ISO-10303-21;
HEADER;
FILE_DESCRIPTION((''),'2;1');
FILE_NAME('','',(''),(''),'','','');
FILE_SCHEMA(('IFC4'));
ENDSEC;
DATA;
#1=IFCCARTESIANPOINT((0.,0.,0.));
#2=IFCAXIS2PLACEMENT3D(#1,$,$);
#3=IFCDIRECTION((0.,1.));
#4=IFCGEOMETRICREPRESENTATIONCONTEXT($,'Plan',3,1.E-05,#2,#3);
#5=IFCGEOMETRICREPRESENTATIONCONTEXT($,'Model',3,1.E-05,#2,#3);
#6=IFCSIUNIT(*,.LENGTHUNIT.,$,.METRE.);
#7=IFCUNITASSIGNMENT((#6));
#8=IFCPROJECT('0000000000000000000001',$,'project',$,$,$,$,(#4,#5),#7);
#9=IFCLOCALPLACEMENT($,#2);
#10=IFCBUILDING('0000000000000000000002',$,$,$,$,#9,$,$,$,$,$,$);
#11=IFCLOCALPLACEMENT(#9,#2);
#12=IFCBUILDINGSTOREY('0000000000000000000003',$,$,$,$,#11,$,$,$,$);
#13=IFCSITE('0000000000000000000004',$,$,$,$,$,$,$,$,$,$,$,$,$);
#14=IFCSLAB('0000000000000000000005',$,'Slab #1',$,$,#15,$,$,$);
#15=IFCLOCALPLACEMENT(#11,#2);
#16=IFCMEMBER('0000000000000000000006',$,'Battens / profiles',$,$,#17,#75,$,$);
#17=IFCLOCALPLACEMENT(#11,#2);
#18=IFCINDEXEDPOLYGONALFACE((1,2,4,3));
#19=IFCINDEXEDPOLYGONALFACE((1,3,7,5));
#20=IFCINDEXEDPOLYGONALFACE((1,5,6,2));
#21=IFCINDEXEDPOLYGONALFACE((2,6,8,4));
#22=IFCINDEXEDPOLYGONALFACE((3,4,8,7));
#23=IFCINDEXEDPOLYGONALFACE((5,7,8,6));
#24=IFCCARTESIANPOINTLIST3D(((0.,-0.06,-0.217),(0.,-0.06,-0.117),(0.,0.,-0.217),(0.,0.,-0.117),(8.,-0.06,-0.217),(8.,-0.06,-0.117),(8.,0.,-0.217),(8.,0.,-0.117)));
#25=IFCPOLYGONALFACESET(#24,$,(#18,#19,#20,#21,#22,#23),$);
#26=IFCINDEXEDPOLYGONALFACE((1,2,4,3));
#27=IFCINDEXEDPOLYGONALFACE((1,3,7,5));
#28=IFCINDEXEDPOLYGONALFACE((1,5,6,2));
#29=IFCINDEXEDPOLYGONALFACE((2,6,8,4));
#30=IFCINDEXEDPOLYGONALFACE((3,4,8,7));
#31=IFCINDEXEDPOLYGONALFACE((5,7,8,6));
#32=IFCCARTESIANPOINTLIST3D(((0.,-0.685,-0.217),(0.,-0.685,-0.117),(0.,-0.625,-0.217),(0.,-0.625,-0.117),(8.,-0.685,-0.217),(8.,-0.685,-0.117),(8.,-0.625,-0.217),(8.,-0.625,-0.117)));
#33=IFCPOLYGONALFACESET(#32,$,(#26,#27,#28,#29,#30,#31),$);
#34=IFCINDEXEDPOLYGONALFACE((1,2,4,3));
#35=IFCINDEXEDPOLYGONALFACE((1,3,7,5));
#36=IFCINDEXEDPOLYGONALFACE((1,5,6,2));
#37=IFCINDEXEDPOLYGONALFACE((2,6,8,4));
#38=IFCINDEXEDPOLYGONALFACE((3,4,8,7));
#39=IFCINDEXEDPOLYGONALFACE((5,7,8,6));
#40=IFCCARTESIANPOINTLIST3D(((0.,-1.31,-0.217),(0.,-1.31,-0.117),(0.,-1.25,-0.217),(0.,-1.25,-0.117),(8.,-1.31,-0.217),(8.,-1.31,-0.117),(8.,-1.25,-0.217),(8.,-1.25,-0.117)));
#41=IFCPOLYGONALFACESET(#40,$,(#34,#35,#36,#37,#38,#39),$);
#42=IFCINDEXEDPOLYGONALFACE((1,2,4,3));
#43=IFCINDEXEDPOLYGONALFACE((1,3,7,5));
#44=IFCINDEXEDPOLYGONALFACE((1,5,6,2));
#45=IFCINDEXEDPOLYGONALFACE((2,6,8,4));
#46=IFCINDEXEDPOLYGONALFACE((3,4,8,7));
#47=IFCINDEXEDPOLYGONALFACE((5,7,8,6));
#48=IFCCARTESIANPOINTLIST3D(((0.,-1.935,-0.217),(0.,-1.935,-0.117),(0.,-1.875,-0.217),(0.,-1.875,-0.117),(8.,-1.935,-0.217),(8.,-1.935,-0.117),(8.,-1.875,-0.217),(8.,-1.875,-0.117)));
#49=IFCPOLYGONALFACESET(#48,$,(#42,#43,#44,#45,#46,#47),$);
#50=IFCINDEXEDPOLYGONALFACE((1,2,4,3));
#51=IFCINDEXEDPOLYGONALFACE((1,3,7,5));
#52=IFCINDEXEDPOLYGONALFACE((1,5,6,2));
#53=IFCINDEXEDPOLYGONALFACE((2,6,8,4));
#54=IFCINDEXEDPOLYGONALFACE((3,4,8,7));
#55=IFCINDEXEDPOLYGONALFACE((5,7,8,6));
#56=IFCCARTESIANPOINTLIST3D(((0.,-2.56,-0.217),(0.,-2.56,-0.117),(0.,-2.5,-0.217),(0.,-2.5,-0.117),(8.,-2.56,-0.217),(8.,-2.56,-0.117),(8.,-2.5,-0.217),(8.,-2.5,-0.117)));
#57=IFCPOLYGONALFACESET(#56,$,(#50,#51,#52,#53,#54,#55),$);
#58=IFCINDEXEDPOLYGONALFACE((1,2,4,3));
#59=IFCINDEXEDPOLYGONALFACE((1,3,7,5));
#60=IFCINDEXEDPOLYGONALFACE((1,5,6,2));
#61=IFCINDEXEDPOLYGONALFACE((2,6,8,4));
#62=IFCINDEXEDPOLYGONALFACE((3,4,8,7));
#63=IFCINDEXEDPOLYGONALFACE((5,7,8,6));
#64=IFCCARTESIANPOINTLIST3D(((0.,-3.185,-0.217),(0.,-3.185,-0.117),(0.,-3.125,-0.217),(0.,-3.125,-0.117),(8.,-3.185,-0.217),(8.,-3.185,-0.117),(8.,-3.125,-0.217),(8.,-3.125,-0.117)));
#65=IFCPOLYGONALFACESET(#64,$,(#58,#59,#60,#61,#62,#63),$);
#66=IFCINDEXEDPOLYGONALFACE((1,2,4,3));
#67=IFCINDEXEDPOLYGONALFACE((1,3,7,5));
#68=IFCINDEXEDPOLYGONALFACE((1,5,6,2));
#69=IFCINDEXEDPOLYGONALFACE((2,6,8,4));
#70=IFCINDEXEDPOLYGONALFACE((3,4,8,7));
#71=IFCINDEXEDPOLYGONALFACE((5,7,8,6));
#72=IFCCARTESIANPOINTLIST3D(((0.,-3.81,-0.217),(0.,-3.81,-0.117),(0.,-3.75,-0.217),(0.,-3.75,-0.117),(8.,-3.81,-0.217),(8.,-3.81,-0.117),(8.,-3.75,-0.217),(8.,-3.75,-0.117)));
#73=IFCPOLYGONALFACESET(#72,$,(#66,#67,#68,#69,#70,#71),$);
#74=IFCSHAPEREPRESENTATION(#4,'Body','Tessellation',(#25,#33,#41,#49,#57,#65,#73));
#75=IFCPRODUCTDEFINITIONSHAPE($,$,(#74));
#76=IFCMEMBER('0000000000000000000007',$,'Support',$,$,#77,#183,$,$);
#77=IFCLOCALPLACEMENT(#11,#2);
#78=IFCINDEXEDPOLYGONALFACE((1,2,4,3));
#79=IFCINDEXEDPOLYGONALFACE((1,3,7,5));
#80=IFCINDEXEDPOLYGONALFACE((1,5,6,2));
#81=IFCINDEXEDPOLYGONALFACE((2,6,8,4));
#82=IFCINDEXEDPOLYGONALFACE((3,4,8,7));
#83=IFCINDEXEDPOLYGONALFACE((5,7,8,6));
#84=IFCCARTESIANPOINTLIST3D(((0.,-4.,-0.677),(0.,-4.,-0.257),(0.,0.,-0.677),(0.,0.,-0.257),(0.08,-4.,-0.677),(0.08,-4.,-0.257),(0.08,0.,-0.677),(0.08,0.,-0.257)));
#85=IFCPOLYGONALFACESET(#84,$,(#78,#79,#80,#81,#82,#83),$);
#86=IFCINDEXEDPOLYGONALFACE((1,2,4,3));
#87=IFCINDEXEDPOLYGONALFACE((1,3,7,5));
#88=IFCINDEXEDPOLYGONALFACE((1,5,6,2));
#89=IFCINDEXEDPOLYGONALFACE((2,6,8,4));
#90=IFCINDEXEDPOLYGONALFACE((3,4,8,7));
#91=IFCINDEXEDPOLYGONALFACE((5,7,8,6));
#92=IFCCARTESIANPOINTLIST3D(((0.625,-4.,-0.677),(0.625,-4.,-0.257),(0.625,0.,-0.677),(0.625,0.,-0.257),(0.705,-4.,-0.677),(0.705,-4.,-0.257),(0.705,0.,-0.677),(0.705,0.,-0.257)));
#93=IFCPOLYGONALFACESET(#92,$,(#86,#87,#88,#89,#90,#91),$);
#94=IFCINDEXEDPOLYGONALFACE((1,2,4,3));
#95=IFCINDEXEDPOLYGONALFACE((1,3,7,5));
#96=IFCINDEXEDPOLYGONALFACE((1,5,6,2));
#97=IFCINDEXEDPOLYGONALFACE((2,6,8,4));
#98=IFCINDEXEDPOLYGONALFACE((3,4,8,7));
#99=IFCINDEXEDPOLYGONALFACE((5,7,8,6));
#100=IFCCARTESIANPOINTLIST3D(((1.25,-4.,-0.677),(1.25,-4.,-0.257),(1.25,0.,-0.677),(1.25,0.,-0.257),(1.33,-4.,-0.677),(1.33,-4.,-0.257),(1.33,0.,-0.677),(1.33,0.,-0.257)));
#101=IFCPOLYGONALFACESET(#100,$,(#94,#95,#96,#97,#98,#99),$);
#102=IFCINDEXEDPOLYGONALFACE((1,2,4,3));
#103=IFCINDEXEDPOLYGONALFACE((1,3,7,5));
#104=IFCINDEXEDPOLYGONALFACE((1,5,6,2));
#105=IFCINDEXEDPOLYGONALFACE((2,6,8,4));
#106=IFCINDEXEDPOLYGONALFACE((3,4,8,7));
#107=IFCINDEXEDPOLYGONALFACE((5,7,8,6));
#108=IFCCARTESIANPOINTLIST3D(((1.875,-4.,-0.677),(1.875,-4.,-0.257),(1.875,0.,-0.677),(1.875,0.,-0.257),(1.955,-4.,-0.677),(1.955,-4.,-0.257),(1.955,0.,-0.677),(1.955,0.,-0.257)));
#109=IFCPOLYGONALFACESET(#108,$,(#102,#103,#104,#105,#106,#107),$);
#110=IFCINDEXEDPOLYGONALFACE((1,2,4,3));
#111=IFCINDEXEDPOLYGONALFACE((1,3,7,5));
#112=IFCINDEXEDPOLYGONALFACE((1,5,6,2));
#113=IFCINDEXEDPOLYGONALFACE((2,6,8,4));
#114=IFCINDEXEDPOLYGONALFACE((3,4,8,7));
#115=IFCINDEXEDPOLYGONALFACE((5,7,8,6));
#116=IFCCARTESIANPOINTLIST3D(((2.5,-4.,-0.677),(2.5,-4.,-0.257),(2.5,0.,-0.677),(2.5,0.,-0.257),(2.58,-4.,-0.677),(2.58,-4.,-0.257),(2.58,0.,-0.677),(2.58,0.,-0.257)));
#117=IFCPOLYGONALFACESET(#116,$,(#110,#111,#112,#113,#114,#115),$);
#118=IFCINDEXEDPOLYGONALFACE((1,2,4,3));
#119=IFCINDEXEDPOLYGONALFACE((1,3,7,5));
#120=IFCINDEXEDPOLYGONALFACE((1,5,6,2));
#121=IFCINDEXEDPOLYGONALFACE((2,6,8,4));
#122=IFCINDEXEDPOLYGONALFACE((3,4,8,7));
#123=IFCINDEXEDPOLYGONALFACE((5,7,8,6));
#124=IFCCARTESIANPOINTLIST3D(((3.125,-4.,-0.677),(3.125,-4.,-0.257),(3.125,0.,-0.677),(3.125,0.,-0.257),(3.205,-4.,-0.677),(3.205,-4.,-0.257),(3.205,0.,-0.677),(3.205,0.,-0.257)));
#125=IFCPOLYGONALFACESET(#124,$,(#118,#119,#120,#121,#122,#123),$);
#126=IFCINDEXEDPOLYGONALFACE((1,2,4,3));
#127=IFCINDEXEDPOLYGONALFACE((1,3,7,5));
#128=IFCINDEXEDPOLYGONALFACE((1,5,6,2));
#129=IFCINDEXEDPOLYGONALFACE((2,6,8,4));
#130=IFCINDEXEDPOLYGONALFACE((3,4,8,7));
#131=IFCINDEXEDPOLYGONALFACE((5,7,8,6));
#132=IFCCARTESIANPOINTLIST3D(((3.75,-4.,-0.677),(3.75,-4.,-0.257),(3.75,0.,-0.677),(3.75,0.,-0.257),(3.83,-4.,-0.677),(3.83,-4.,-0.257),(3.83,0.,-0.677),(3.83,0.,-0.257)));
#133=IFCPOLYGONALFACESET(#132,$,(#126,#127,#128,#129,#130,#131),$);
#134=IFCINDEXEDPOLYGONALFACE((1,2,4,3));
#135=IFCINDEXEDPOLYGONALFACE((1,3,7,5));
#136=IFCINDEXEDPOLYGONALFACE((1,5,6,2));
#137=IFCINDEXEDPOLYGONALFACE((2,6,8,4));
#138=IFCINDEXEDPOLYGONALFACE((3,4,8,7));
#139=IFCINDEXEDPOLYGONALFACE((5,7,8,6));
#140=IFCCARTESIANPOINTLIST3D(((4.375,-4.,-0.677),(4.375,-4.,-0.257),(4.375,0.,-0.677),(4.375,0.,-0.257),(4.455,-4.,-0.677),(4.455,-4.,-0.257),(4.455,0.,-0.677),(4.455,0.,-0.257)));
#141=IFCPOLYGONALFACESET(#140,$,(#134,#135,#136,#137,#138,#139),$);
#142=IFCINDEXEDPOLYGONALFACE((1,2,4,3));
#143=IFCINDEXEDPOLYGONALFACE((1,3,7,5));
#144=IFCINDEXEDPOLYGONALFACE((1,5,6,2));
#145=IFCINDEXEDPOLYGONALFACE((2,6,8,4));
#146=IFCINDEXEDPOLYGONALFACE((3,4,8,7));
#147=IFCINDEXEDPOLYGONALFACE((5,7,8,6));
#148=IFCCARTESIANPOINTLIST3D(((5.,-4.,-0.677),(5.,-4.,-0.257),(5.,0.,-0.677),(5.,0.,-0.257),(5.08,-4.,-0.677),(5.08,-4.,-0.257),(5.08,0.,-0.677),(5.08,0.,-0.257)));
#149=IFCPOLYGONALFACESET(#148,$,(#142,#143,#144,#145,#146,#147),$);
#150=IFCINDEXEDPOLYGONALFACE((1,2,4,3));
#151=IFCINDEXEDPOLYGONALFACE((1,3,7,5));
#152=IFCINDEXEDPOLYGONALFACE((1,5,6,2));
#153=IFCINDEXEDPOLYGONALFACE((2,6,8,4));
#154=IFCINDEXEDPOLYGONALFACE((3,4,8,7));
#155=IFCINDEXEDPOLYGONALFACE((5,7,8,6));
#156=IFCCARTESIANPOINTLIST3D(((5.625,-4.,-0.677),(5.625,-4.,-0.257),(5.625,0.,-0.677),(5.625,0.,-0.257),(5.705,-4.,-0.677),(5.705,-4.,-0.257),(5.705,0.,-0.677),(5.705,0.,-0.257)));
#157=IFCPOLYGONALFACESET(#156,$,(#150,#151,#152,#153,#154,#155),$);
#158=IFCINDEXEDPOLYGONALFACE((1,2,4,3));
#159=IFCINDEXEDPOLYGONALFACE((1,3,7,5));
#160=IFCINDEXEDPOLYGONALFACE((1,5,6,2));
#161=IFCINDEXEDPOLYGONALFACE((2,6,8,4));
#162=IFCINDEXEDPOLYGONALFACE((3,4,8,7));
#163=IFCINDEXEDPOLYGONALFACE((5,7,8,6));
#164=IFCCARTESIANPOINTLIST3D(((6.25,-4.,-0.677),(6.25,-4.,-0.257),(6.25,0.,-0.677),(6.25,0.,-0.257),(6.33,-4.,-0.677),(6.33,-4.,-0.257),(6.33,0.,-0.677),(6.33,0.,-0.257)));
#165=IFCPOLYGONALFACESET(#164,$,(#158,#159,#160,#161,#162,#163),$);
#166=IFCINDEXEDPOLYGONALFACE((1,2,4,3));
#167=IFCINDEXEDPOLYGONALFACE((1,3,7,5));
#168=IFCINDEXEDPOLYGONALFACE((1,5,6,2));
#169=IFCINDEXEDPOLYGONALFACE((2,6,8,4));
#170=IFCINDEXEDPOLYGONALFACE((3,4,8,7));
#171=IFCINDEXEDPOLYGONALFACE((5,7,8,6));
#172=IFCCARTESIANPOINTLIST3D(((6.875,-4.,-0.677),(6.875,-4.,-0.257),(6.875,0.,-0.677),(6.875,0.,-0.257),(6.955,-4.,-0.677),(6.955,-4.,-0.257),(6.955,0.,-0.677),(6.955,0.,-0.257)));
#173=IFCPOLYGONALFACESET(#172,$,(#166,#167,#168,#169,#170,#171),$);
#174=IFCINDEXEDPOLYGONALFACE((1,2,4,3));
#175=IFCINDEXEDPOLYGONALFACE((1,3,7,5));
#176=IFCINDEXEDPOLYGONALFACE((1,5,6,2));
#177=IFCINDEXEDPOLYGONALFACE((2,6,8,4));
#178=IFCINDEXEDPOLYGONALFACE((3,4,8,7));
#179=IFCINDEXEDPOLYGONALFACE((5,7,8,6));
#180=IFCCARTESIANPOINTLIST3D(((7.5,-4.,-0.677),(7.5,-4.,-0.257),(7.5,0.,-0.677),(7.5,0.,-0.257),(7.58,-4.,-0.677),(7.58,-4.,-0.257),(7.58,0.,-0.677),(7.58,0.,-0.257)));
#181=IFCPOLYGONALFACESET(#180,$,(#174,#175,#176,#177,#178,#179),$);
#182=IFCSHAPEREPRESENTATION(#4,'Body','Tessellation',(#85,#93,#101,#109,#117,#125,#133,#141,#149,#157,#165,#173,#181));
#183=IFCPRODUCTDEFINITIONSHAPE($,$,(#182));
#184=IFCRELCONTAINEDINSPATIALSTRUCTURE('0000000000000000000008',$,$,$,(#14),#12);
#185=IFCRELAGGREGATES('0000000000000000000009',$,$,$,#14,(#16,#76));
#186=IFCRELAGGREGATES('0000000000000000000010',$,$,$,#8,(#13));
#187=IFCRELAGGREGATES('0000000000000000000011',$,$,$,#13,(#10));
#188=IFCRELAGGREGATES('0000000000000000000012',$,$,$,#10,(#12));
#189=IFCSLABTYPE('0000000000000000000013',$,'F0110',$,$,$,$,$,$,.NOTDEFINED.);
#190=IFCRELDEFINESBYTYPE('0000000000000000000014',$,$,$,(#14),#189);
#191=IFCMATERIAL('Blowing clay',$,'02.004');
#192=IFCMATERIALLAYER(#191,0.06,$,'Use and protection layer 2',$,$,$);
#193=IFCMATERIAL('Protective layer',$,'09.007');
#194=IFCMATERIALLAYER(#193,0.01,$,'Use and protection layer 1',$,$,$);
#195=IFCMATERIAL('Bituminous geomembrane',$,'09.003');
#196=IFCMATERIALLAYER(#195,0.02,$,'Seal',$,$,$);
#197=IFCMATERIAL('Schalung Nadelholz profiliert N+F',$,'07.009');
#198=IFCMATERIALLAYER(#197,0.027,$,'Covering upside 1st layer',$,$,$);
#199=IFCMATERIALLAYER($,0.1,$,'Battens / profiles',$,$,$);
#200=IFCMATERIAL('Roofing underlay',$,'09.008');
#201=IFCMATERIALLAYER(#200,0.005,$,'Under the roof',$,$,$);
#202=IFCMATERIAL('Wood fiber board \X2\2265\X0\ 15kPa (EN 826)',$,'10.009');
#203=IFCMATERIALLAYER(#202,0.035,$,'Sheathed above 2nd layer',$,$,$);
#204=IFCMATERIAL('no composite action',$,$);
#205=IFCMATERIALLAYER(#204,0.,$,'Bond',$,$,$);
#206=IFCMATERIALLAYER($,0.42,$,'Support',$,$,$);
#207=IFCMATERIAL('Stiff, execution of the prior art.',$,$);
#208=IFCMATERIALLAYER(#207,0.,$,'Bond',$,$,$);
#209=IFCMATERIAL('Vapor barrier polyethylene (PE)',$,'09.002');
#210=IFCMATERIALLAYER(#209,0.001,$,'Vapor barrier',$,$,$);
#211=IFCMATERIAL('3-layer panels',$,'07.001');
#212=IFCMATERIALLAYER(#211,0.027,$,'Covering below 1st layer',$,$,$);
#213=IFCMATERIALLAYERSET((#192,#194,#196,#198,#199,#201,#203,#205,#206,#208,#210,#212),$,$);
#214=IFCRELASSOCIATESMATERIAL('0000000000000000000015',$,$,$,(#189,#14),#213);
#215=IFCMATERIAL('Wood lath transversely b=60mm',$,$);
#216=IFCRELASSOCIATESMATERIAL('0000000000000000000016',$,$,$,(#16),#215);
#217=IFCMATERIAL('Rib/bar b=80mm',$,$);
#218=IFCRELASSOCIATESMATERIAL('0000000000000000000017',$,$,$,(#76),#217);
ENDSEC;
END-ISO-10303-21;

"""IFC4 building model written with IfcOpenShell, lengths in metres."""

from ifc_helpers import new_model, si_unit, direction, frame, frame_2d, origin, place, context, project, spatial, rectangle, extrude, material, layer, layer_set, type_object, element, aggregate, save


model = new_model("IFC4")

# Units and contexts
plan_context = context("Plan", 3, precision=1e-05, world=origin(), true_north=direction((0.0, 1.0)))
model_context = context("Model", 3, precision=1e-05, world=origin(), true_north=direction((0.0, 1.0)))
ifc_project = project(units=[si_unit("LENGTHUNIT", "METRE")], contexts=[plan_context, model_context])

# Site, building, storey
site = spatial("IfcSite", under=ifc_project)
building_placement = place(None, origin())
building = spatial("IfcBuilding", under=site, at=building_placement)
storey_placement = place(building_placement, origin())
storey = spatial("IfcBuildingStorey", under=building, at=storey_placement)

# Slab, members
ifc_material_1 = material(Name="Blowing clay", Category="02.004")
ifc_layer_1 = layer(ifc_material_1, 0.06, Name="Use and protection layer 2")
ifc_material_2 = material(Name="Protective layer", Category="09.007")
ifc_layer_2 = layer(ifc_material_2, 0.01, Name="Use and protection layer 1")
ifc_material_3 = material(Name="Bituminous geomembrane", Category="09.003")
ifc_layer_3 = layer(ifc_material_3, 0.02, Name="Seal")
ifc_material_4 = material(Name="Schalung Nadelholz profiliert N+F", Category="07.009")
ifc_layer_4 = layer(ifc_material_4, 0.027, Name="Covering upside 1st layer")
ifc_layer_5 = layer(None, 0.1, Name="Battens / profiles")
ifc_material_5 = material(Name="Roofing underlay", Category="09.008")
ifc_layer_6 = layer(ifc_material_5, 0.005, Name="Under the roof")
ifc_material_6 = material(Name="Wood fiber board ≥ 15kPa (EN 826)", Category="10.009")
ifc_layer_7 = layer(ifc_material_6, 0.035, Name="Sheathed above 2nd layer")
ifc_material_7 = material(Name="no composite action")
ifc_layer_8 = layer(ifc_material_7, 0.0, Name="Bond")
ifc_layer_9 = layer(None, 0.42, Name="Support")
ifc_material_8 = material(Name="Stiff, execution of the prior art.")
ifc_layer_10 = layer(ifc_material_8, 0.0, Name="Bond")
ifc_material_9 = material(Name="Vapor barrier polyethylene (PE)", Category="09.002")
ifc_layer_11 = layer(ifc_material_9, 0.001, Name="Vapor barrier")
ifc_material_10 = material(Name="3-layer panels", Category="07.001")
ifc_layer_12 = layer(ifc_material_10, 0.027, Name="Covering below 1st layer")
ifc_layer_set = layer_set([ifc_layer_1, ifc_layer_2, ifc_layer_3, ifc_layer_4, ifc_layer_5, ifc_layer_6, ifc_layer_7, ifc_layer_8, ifc_layer_9, ifc_layer_10, ifc_layer_11, ifc_layer_12])
slab_type = type_object("IfcSlabType", Name="F0110", PredefinedType="NOTDEFINED", material=ifc_layer_set)
slab_placement = place(None, frame((0.0, 0.0, 0.0), z_axis=(0.0, 0.0, -1.0), x_axis=(1.0, 0.0, 0.0)))
slab = element("IfcSlab", 1, at=slab_placement, inside=storey, type_object=slab_type, material=ifc_layer_set, Name="Slab #1")
ifc_material_11 = material(Name="Wood lath transversely b=60mm")
member_1_placement = place(slab_placement, origin())
member_1 = element("IfcMember", 2, at=member_1_placement, material=ifc_material_11, Name="Battens / profiles", context=plan_context, shape_type="SweptSolid", body=[
    extrude(rectangle(XDim=0.06, YDim=0.1, at=frame_2d((0.03, 0.05), x_axis=(1.0, 0.0))), frame((0.0, 0.0, 0.117), z_axis=(1.0, 0.0, 0.0), x_axis=(0.0, 1.0, 0.0)), (0.0, 0.0, 1.0), 8.0),
    extrude(rectangle(XDim=0.06, YDim=0.1, at=frame_2d((0.03, 0.05), x_axis=(1.0, 0.0))), frame((0.0, 0.625, 0.117), z_axis=(1.0, 0.0, 0.0), x_axis=(0.0, 1.0, 0.0)), (0.0, 0.0, 1.0), 8.0),
    extrude(rectangle(XDim=0.06, YDim=0.1, at=frame_2d((0.03, 0.05), x_axis=(1.0, 0.0))), frame((0.0, 1.25, 0.117), z_axis=(1.0, 0.0, 0.0), x_axis=(0.0, 1.0, 0.0)), (0.0, 0.0, 1.0), 8.0),
    extrude(rectangle(XDim=0.06, YDim=0.1, at=frame_2d((0.03, 0.05), x_axis=(1.0, 0.0))), frame((0.0, 1.875, 0.117), z_axis=(1.0, 0.0, 0.0), x_axis=(0.0, 1.0, 0.0)), (0.0, 0.0, 1.0), 8.0),
    extrude(rectangle(XDim=0.06, YDim=0.1, at=frame_2d((0.03, 0.05), x_axis=(1.0, 0.0))), frame((0.0, 2.5, 0.117), z_axis=(1.0, 0.0, 0.0), x_axis=(0.0, 1.0, 0.0)), (0.0, 0.0, 1.0), 8.0),
    extrude(rectangle(XDim=0.06, YDim=0.1, at=frame_2d((0.03, 0.05), x_axis=(1.0, 0.0))), frame((0.0, 3.125, 0.117), z_axis=(1.0, 0.0, 0.0), x_axis=(0.0, 1.0, 0.0)), (0.0, 0.0, 1.0), 8.0),
    extrude(rectangle(XDim=0.06, YDim=0.1, at=frame_2d((0.03, 0.05), x_axis=(1.0, 0.0))), frame((0.0, 3.75, 0.117), z_axis=(1.0, 0.0, 0.0), x_axis=(0.0, 1.0, 0.0)), (0.0, 0.0, 1.0), 8.0),
])
ifc_material_12 = material(Name="Rib/bar b=80mm")
member_2_placement = place(slab_placement, origin())
member_2 = element("IfcMember", 3, at=member_2_placement, material=ifc_material_12, Name="Support", context=plan_context, shape_type="SweptSolid", body=[
    extrude(rectangle(XDim=0.08, YDim=0.42, at=frame_2d((0.04, 0.21), x_axis=(1.0, 0.0))), frame((0.0, 4.0, 0.257), z_axis=(0.0, -1.0, 0.0), x_axis=(1.0, 0.0, 0.0)), (0.0, 0.0, 1.0), 4.0),
    extrude(rectangle(XDim=0.08, YDim=0.42, at=frame_2d((0.04, 0.21), x_axis=(1.0, 0.0))), frame((0.625, 4.0, 0.257), z_axis=(0.0, -1.0, 0.0), x_axis=(1.0, 0.0, 0.0)), (0.0, 0.0, 1.0), 4.0),
    extrude(rectangle(XDim=0.08, YDim=0.42, at=frame_2d((0.04, 0.21), x_axis=(1.0, 0.0))), frame((1.25, 4.0, 0.257), z_axis=(0.0, -1.0, 0.0), x_axis=(1.0, 0.0, 0.0)), (0.0, 0.0, 1.0), 4.0),
    extrude(rectangle(XDim=0.08, YDim=0.42, at=frame_2d((0.04, 0.21), x_axis=(1.0, 0.0))), frame((1.875, 4.0, 0.257), z_axis=(0.0, -1.0, 0.0), x_axis=(1.0, 0.0, 0.0)), (0.0, 0.0, 1.0), 4.0),
    extrude(rectangle(XDim=0.08, YDim=0.42, at=frame_2d((0.04, 0.21), x_axis=(1.0, 0.0))), frame((2.5, 4.0, 0.257), z_axis=(0.0, -1.0, 0.0), x_axis=(1.0, 0.0, 0.0)), (0.0, 0.0, 1.0), 4.0),
    extrude(rectangle(XDim=0.08, YDim=0.42, at=frame_2d((0.04, 0.21), x_axis=(1.0, 0.0))), frame((3.125, 4.0, 0.257), z_axis=(0.0, -1.0, 0.0), x_axis=(1.0, 0.0, 0.0)), (0.0, 0.0, 1.0), 4.0),
    extrude(rectangle(XDim=0.08, YDim=0.42, at=frame_2d((0.04, 0.21), x_axis=(1.0, 0.0))), frame((3.75, 4.0, 0.257), z_axis=(0.0, -1.0, 0.0), x_axis=(1.0, 0.0, 0.0)), (0.0, 0.0, 1.0), 4.0),
    extrude(rectangle(XDim=0.08, YDim=0.42, at=frame_2d((0.04, 0.21), x_axis=(1.0, 0.0))), frame((4.375, 4.0, 0.257), z_axis=(0.0, -1.0, 0.0), x_axis=(1.0, 0.0, 0.0)), (0.0, 0.0, 1.0), 4.0),
    extrude(rectangle(XDim=0.08, YDim=0.42, at=frame_2d((0.04, 0.21), x_axis=(1.0, 0.0))), frame((5.0, 4.0, 0.257), z_axis=(0.0, -1.0, 0.0), x_axis=(1.0, 0.0, 0.0)), (0.0, 0.0, 1.0), 4.0),
    extrude(rectangle(XDim=0.08, YDim=0.42, at=frame_2d((0.04, 0.21), x_axis=(1.0, 0.0))), frame((5.625, 4.0, 0.257), z_axis=(0.0, -1.0, 0.0), x_axis=(1.0, 0.0, 0.0)), (0.0, 0.0, 1.0), 4.0),
    extrude(rectangle(XDim=0.08, YDim=0.42, at=frame_2d((0.04, 0.21), x_axis=(1.0, 0.0))), frame((6.25, 4.0, 0.257), z_axis=(0.0, -1.0, 0.0), x_axis=(1.0, 0.0, 0.0)), (0.0, 0.0, 1.0), 4.0),
    extrude(rectangle(XDim=0.08, YDim=0.42, at=frame_2d((0.04, 0.21), x_axis=(1.0, 0.0))), frame((6.875, 4.0, 0.257), z_axis=(0.0, -1.0, 0.0), x_axis=(1.0, 0.0, 0.0)), (0.0, 0.0, 1.0), 4.0),
    extrude(rectangle(XDim=0.08, YDim=0.42, at=frame_2d((0.04, 0.21), x_axis=(1.0, 0.0))), frame((7.5, 4.0, 0.257), z_axis=(0.0, -1.0, 0.0), x_axis=(1.0, 0.0, 0.0)), (0.0, 0.0, 1.0), 4.0),
])
aggregate(slab, [member_1, member_2])

save(model, "model.ifc")
